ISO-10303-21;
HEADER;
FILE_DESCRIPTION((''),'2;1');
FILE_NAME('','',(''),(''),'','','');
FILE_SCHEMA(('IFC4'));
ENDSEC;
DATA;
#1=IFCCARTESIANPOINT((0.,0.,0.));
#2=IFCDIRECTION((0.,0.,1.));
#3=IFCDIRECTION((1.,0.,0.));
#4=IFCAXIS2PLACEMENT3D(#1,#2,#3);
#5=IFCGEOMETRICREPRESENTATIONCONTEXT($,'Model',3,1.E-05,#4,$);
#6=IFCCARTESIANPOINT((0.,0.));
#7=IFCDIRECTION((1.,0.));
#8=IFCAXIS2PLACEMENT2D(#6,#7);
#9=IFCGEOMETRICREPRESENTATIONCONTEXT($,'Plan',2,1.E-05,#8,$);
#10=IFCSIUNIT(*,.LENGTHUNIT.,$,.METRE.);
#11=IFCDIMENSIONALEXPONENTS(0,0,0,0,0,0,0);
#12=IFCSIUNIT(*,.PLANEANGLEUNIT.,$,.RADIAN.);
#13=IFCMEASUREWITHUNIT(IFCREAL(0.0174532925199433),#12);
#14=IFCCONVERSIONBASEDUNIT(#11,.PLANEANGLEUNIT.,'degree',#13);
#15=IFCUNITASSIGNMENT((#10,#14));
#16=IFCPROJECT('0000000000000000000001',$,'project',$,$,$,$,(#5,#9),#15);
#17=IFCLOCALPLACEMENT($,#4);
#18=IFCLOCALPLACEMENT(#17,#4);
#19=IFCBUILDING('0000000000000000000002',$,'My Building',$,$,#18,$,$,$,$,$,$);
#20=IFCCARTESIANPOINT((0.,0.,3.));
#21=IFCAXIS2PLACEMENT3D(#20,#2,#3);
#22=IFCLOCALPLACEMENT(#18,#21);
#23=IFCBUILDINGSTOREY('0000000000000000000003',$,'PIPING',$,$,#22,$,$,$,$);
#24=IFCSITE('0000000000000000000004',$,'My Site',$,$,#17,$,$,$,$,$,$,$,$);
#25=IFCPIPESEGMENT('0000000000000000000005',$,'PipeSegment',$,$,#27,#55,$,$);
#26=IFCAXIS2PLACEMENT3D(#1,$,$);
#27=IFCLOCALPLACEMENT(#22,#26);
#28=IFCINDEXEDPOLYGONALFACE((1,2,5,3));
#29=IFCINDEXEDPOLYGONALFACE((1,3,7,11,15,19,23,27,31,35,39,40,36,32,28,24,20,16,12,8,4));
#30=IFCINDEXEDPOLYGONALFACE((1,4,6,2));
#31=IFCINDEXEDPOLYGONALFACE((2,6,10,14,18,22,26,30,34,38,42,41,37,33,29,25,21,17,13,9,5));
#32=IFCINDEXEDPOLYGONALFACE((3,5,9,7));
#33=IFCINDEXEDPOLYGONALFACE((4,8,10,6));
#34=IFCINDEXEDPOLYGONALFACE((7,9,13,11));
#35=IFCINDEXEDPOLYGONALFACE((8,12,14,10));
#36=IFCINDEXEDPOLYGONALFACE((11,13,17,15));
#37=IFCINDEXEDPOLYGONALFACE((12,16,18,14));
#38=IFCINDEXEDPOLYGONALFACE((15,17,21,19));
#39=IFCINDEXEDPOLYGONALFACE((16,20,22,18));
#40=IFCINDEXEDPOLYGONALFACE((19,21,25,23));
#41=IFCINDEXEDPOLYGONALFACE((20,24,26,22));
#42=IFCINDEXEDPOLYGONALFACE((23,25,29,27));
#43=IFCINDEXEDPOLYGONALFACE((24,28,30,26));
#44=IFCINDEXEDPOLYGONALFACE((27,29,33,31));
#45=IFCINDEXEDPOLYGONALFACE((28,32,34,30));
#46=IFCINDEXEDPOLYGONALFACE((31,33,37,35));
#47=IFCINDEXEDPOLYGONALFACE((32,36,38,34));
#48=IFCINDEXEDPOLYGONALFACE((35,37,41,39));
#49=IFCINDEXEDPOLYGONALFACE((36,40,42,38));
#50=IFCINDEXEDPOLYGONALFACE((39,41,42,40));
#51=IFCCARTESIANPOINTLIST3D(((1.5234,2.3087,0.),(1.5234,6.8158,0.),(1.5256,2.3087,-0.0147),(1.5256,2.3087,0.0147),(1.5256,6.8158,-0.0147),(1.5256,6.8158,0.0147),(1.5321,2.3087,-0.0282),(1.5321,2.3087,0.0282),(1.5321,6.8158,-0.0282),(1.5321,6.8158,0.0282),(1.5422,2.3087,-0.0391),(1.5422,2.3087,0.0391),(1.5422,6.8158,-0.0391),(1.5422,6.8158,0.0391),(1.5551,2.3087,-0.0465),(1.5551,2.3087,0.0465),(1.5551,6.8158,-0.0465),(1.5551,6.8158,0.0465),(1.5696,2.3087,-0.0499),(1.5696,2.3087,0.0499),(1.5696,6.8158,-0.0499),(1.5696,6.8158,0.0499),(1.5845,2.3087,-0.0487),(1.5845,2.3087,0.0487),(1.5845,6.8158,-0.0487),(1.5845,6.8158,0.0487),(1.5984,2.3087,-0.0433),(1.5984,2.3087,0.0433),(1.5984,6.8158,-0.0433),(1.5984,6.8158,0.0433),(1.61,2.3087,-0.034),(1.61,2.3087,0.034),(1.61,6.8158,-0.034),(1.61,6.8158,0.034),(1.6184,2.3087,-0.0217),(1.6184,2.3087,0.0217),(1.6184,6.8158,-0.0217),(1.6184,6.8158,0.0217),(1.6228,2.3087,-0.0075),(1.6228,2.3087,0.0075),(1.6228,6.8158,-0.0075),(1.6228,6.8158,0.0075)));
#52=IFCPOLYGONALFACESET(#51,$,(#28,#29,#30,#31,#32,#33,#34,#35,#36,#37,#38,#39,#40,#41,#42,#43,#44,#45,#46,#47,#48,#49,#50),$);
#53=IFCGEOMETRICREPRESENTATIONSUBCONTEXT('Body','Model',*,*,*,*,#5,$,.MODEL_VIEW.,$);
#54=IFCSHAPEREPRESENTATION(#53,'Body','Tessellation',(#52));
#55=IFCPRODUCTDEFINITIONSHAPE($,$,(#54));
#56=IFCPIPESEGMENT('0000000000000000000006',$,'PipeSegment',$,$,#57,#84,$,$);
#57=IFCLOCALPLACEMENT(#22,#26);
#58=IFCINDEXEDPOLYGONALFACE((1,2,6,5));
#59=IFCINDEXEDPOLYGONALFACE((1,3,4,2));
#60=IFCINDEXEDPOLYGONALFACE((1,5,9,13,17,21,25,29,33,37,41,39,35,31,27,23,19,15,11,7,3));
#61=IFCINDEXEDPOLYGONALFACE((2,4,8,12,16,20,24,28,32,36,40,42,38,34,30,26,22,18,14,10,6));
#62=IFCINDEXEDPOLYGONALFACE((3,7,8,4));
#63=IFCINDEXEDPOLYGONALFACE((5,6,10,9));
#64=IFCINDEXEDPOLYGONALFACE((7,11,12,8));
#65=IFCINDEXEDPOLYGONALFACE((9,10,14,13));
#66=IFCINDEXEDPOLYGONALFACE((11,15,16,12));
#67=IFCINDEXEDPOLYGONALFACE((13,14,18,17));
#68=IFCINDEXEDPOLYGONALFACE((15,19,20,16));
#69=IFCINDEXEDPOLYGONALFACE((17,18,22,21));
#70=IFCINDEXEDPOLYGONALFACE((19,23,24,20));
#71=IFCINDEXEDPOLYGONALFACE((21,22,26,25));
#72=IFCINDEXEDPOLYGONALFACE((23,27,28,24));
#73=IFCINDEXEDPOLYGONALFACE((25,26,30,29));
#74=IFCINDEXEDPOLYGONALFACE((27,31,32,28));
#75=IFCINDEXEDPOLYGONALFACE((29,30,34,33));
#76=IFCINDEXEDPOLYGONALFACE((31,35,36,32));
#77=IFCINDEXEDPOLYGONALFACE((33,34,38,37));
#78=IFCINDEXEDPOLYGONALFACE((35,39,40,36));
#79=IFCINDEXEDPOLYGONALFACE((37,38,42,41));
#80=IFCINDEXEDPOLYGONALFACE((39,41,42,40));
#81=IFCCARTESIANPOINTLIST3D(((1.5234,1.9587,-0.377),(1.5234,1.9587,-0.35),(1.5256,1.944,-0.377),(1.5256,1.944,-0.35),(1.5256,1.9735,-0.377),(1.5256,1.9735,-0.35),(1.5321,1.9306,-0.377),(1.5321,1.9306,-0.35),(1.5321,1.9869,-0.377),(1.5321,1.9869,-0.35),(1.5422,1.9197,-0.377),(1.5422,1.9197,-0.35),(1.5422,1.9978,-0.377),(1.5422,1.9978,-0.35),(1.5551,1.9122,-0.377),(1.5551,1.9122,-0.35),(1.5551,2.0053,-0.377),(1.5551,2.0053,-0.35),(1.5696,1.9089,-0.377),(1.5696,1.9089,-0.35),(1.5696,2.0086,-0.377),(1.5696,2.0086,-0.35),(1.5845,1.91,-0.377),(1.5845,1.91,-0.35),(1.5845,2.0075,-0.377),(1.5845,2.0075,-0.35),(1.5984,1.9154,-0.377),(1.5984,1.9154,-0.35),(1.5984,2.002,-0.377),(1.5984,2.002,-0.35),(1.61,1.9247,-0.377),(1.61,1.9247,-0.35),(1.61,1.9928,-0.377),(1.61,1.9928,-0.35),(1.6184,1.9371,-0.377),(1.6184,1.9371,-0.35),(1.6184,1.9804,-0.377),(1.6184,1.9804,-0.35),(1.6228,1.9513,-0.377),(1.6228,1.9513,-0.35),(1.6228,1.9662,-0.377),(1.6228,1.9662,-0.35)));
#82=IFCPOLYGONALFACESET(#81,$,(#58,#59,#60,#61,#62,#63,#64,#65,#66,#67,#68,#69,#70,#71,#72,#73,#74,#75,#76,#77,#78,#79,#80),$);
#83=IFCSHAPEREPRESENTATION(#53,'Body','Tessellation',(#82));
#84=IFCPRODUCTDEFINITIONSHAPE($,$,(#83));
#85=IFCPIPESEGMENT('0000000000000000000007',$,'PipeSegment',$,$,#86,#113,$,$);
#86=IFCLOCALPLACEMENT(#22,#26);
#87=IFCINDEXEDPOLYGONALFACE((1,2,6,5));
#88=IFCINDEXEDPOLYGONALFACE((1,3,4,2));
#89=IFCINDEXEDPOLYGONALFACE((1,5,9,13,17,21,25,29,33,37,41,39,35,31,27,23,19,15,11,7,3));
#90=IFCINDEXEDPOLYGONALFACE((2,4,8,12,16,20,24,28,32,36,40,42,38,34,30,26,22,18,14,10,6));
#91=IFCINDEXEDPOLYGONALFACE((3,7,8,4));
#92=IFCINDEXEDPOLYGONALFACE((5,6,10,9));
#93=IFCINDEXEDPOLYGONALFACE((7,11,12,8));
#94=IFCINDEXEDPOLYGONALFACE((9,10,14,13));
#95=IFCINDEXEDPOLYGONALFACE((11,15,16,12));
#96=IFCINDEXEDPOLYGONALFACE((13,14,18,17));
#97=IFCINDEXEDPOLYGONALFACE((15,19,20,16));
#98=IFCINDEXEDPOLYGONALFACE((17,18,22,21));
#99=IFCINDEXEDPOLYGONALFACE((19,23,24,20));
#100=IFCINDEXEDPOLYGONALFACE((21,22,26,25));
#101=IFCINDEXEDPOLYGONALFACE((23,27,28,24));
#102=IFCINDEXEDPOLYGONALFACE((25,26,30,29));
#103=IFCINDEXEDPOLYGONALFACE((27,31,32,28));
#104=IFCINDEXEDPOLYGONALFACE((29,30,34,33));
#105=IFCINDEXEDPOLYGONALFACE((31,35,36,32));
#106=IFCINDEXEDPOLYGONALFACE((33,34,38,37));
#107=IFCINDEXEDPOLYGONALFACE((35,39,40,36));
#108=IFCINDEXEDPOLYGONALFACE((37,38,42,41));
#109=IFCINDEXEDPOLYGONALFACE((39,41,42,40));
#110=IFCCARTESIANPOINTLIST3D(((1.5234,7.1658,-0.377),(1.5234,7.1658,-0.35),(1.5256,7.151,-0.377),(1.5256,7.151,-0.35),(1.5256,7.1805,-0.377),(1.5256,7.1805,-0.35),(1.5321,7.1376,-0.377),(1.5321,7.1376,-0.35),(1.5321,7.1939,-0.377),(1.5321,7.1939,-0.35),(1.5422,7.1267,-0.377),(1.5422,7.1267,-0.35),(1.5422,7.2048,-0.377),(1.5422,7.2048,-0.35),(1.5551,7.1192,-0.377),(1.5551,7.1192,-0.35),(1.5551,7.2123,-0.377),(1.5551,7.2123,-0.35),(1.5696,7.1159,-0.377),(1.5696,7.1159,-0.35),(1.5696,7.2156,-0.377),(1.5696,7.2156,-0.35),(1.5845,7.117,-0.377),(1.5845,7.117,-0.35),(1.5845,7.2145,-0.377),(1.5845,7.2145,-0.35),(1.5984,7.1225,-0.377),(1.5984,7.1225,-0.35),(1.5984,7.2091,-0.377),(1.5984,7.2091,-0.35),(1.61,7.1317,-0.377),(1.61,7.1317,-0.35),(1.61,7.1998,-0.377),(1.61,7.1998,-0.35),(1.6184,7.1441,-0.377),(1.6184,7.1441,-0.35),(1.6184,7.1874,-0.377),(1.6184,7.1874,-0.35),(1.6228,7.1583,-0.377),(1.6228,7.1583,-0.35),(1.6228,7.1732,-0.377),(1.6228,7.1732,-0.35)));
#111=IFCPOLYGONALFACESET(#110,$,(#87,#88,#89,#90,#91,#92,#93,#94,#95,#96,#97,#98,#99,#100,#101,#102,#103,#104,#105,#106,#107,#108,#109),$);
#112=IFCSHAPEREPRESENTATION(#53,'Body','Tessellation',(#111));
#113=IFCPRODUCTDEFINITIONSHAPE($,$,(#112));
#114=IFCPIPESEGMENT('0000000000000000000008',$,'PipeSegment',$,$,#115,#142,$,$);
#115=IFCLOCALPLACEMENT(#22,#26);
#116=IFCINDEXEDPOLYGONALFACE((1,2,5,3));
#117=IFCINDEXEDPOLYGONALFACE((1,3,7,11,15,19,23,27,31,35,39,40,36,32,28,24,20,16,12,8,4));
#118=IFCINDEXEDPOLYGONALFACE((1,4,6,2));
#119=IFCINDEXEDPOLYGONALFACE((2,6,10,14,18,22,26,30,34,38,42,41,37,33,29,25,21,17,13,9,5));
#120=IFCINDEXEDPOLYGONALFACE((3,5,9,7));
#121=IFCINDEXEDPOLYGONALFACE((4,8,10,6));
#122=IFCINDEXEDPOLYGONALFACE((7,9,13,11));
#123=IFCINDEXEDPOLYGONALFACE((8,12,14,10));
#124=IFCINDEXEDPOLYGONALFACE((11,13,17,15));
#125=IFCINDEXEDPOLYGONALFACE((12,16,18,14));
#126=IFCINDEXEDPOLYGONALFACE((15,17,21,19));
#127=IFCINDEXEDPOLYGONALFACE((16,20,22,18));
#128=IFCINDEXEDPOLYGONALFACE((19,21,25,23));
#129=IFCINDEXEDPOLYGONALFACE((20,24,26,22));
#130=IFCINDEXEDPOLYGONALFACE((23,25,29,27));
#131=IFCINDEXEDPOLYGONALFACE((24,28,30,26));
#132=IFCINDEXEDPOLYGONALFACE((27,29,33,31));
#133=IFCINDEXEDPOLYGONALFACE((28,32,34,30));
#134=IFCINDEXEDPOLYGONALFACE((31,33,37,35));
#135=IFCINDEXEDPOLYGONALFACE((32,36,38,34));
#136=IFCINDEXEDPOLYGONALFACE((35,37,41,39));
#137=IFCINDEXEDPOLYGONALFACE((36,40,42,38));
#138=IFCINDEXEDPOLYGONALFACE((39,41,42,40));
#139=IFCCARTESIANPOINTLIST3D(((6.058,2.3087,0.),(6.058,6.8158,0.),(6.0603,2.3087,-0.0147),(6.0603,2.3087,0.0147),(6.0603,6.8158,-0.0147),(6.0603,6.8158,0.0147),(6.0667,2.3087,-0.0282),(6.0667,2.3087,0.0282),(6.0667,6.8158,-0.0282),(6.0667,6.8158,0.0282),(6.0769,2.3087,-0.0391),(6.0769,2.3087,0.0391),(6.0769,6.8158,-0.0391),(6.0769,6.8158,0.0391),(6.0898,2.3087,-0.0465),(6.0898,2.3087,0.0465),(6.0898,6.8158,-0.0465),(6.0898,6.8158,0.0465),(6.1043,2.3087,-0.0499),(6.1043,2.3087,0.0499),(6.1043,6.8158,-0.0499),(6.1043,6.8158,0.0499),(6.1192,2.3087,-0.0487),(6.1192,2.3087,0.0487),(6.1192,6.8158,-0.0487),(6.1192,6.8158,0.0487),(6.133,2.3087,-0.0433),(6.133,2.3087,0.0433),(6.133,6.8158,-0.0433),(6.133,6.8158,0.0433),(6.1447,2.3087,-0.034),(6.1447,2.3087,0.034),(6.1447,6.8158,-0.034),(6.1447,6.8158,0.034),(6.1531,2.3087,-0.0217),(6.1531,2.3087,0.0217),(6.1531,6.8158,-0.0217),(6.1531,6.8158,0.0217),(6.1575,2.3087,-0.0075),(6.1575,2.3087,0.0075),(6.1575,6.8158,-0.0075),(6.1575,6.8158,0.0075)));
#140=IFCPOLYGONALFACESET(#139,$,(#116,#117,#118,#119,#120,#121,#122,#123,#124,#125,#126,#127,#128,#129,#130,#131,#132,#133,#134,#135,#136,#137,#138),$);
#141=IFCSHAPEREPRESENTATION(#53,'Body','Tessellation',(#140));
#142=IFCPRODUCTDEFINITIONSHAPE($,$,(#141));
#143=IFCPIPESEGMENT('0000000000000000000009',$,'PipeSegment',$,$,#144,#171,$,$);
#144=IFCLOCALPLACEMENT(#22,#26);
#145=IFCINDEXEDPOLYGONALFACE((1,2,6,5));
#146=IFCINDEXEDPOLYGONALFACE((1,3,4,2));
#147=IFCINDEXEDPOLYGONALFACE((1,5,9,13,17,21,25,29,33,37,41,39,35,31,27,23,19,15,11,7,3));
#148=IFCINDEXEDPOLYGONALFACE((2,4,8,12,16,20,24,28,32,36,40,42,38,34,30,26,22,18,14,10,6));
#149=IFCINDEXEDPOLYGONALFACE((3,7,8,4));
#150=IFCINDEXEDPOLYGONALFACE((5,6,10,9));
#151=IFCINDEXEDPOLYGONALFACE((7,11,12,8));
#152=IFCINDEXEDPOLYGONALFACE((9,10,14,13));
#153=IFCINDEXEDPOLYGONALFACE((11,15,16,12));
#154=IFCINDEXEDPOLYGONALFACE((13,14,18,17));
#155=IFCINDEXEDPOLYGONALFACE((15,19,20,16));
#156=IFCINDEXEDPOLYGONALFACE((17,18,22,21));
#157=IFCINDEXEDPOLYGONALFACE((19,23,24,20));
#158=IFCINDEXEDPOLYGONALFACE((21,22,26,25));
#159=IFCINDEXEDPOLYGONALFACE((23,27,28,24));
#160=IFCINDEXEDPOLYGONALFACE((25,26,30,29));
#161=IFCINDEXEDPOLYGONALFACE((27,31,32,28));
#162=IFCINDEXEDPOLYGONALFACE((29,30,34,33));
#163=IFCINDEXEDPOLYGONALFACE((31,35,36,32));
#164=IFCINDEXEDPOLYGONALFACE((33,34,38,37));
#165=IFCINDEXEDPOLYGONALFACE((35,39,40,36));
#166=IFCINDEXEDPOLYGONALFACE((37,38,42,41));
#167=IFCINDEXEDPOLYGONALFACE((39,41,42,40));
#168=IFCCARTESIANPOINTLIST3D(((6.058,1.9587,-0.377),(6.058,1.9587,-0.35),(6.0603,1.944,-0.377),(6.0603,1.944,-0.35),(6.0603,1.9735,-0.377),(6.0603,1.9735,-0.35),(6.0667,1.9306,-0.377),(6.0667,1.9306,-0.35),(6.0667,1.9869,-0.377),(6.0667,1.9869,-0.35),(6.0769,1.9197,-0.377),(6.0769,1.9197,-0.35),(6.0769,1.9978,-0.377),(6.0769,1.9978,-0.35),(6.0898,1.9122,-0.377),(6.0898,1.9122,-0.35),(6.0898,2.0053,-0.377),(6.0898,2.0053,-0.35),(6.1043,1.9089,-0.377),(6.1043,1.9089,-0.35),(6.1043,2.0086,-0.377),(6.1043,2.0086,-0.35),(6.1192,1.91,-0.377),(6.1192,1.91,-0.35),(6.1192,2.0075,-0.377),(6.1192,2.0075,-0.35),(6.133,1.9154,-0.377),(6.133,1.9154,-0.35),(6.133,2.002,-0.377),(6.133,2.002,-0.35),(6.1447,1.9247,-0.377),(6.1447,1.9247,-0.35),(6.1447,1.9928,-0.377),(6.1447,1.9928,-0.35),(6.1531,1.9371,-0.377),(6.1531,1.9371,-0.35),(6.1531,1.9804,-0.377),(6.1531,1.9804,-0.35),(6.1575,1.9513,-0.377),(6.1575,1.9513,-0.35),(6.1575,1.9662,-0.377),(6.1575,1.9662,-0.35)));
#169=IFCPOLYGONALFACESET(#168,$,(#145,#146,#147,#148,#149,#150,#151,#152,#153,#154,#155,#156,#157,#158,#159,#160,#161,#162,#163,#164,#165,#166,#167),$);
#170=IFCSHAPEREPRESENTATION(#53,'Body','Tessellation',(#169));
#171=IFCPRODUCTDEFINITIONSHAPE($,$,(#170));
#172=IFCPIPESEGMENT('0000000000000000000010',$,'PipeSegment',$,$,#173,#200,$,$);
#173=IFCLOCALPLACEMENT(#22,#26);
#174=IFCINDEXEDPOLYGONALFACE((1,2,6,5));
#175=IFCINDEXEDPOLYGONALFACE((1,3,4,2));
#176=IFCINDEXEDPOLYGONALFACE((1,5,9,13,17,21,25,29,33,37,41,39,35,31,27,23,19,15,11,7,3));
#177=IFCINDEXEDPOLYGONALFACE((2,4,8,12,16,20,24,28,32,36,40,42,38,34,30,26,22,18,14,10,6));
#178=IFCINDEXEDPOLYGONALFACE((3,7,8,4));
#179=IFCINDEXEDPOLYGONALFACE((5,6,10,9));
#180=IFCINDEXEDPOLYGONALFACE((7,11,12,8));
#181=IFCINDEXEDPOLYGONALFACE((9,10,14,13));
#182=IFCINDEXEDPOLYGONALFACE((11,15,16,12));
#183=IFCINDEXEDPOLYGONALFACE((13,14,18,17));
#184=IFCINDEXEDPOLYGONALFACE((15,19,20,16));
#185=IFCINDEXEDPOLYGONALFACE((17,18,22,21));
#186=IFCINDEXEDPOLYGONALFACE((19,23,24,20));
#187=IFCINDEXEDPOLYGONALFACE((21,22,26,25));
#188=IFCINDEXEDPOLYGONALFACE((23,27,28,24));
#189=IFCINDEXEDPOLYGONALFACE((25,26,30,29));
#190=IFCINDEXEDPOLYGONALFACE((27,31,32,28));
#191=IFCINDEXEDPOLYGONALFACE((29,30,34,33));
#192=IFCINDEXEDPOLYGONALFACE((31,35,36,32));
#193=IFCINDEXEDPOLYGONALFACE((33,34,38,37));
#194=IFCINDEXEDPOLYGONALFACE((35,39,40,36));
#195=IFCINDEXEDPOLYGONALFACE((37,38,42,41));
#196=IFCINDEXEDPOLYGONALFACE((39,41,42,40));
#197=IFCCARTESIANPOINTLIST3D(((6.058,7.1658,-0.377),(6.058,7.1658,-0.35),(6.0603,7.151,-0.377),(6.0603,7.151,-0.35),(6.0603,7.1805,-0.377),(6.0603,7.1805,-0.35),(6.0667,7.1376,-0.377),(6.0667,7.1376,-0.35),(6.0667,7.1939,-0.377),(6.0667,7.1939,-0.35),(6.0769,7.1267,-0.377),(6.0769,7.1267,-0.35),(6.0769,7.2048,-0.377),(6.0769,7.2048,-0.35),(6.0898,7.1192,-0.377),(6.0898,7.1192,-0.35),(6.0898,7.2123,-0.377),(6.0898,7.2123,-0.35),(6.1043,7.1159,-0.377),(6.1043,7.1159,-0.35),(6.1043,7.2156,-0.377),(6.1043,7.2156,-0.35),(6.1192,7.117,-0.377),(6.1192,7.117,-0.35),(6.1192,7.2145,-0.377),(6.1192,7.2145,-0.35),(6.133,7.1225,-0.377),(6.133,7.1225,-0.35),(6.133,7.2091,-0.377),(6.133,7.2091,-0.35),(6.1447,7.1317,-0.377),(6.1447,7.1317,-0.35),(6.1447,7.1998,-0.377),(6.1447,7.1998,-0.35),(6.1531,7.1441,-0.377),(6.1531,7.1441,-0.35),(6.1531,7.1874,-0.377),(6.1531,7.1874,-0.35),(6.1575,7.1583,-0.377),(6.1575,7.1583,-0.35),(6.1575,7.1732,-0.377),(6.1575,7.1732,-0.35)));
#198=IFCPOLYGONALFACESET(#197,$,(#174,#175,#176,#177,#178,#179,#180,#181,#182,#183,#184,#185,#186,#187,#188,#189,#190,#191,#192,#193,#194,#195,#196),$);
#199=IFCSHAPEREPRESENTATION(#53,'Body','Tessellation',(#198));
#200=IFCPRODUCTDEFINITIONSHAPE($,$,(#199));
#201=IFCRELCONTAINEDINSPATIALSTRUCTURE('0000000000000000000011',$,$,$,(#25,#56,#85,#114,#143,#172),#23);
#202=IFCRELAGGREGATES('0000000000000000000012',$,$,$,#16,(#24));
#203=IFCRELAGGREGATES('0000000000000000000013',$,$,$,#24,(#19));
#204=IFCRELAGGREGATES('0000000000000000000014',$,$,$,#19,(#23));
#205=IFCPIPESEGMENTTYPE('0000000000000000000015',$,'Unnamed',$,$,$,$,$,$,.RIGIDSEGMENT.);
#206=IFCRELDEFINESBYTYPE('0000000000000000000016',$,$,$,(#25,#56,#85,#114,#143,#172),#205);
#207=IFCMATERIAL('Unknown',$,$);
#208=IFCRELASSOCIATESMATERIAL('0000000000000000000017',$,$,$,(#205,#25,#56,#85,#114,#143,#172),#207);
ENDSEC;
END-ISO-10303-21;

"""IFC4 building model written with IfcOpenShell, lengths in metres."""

from ifc_helpers import new_model, entity, si_unit, converted_unit, frame, origin_with_axes, origin_2d_with_axis, place, context, subcontext, project, spatial, circle, extrude, material, material_profile, profile_set, profile_usage, type_object, element, save


model = new_model("IFC4")

# Units and contexts
model_context = context("Model", 3, precision=1e-05, world=origin_with_axes())
plan_context = context("Plan", 2, precision=1e-05, world=origin_2d_with_axis())
body_context = subcontext(model_context, "Body", "Model", "MODEL_VIEW")
ifc_project = project(units=[si_unit("LENGTHUNIT", "METRE"), converted_unit("PLANEANGLEUNIT", "degree", entity("IfcReal", 0.0174532925199433), si_unit("PLANEANGLEUNIT", "RADIAN"), dimensions=[0, 0, 0, 0, 0, 0, 0])], contexts=[model_context, plan_context])

# Site, building, storey
site_placement = place(None, origin_with_axes())
site = spatial("IfcSite", under=ifc_project, at=site_placement, Name="My Site")
building_placement = place(site_placement, origin_with_axes())
building = spatial("IfcBuilding", under=site, at=building_placement, Name="My Building")
storey_placement = place(building_placement, frame((0.0, 0.0, 3.0), z_axis=(0.0, 0.0, 1.0), x_axis=(1.0, 0.0, 0.0)))
storey = spatial("IfcBuildingStorey", under=building, at=storey_placement, Name="PIPING")

# Pipe segments
ifc_material = material(Name="Unknown")
ifc_material_profile = material_profile(ifc_material, circle(Radius=0.05))
ifc_profile_set = profile_set([ifc_material_profile])
ifc_profile_usage_1 = profile_usage(ifc_profile_set, cardinal=5)
pipe_segment_type = type_object("IfcPipeSegmentType", Name="Unnamed", PredefinedType="RIGIDSEGMENT", material=ifc_profile_set)
pipe_segment_1_placement = place(storey_placement, frame((1.5734, 2.3087, 0.0), z_axis=(0.0, 1.0, 0.0), x_axis=(-1.0, 0.0, 0.0)))
element("IfcPipeSegment", 1, at=pipe_segment_1_placement, inside=storey, type_object=pipe_segment_type, material=ifc_profile_usage_1, Name="PipeSegment", context=body_context, shape_type="SweptSolid", body=[
    extrude(circle(Radius=0.05), origin_with_axes(), (0.0, 0.0, 1.0), 4.507),
])
ifc_profile_usage_2 = profile_usage(ifc_profile_set, cardinal=5)
pipe_segment_2_placement = place(storey_placement, frame((1.5734, 1.9587, -0.35), z_axis=(0.0, 0.0, -1.0), x_axis=(-1.0, 0.0, 0.0)))
element("IfcPipeSegment", 2, at=pipe_segment_2_placement, inside=storey, type_object=pipe_segment_type, material=ifc_profile_usage_2, Name="PipeSegment", context=body_context, shape_type="SweptSolid", body=[
    extrude(circle(Radius=0.05), origin_with_axes(), (0.0, 0.0, 1.0), 0.027),
])
ifc_profile_usage_3 = profile_usage(ifc_profile_set, cardinal=5)
pipe_segment_3_placement = place(storey_placement, frame((1.5734, 7.1658, -0.35), z_axis=(0.0, 0.0, -1.0), x_axis=(-1.0, 0.0, 0.0)))
element("IfcPipeSegment", 3, at=pipe_segment_3_placement, inside=storey, type_object=pipe_segment_type, material=ifc_profile_usage_3, Name="PipeSegment", context=body_context, shape_type="SweptSolid", body=[
    extrude(circle(Radius=0.05), origin_with_axes(), (0.0, 0.0, 1.0), 0.027),
])
ifc_profile_usage_4 = profile_usage(ifc_profile_set, cardinal=5)
pipe_segment_4_placement = place(storey_placement, frame((6.108, 2.3087, 0.0), z_axis=(0.0, 1.0, 0.0), x_axis=(-1.0, 0.0, 0.0)))
element("IfcPipeSegment", 4, at=pipe_segment_4_placement, inside=storey, type_object=pipe_segment_type, material=ifc_profile_usage_4, Name="PipeSegment", context=body_context, shape_type="SweptSolid", body=[
    extrude(circle(Radius=0.05), origin_with_axes(), (0.0, 0.0, 1.0), 4.507),
])
ifc_profile_usage_5 = profile_usage(ifc_profile_set, cardinal=5)
pipe_segment_5_placement = place(storey_placement, frame((6.108, 1.9587, -0.35), z_axis=(0.0, 0.0, -1.0), x_axis=(-1.0, 0.0, 0.0)))
element("IfcPipeSegment", 5, at=pipe_segment_5_placement, inside=storey, type_object=pipe_segment_type, material=ifc_profile_usage_5, Name="PipeSegment", context=body_context, shape_type="SweptSolid", body=[
    extrude(circle(Radius=0.05), origin_with_axes(), (0.0, 0.0, 1.0), 0.027),
])
ifc_profile_usage_6 = profile_usage(ifc_profile_set, cardinal=5)
pipe_segment_6_placement = place(storey_placement, frame((6.108, 7.1658, -0.35), z_axis=(0.0, 0.0, -1.0), x_axis=(-1.0, 0.0, 0.0)))
element("IfcPipeSegment", 6, at=pipe_segment_6_placement, inside=storey, type_object=pipe_segment_type, material=ifc_profile_usage_6, Name="PipeSegment", context=body_context, shape_type="SweptSolid", body=[
    extrude(circle(Radius=0.05), origin_with_axes(), (0.0, 0.0, 1.0), 0.027),
])

save(model, "model.ifc")
